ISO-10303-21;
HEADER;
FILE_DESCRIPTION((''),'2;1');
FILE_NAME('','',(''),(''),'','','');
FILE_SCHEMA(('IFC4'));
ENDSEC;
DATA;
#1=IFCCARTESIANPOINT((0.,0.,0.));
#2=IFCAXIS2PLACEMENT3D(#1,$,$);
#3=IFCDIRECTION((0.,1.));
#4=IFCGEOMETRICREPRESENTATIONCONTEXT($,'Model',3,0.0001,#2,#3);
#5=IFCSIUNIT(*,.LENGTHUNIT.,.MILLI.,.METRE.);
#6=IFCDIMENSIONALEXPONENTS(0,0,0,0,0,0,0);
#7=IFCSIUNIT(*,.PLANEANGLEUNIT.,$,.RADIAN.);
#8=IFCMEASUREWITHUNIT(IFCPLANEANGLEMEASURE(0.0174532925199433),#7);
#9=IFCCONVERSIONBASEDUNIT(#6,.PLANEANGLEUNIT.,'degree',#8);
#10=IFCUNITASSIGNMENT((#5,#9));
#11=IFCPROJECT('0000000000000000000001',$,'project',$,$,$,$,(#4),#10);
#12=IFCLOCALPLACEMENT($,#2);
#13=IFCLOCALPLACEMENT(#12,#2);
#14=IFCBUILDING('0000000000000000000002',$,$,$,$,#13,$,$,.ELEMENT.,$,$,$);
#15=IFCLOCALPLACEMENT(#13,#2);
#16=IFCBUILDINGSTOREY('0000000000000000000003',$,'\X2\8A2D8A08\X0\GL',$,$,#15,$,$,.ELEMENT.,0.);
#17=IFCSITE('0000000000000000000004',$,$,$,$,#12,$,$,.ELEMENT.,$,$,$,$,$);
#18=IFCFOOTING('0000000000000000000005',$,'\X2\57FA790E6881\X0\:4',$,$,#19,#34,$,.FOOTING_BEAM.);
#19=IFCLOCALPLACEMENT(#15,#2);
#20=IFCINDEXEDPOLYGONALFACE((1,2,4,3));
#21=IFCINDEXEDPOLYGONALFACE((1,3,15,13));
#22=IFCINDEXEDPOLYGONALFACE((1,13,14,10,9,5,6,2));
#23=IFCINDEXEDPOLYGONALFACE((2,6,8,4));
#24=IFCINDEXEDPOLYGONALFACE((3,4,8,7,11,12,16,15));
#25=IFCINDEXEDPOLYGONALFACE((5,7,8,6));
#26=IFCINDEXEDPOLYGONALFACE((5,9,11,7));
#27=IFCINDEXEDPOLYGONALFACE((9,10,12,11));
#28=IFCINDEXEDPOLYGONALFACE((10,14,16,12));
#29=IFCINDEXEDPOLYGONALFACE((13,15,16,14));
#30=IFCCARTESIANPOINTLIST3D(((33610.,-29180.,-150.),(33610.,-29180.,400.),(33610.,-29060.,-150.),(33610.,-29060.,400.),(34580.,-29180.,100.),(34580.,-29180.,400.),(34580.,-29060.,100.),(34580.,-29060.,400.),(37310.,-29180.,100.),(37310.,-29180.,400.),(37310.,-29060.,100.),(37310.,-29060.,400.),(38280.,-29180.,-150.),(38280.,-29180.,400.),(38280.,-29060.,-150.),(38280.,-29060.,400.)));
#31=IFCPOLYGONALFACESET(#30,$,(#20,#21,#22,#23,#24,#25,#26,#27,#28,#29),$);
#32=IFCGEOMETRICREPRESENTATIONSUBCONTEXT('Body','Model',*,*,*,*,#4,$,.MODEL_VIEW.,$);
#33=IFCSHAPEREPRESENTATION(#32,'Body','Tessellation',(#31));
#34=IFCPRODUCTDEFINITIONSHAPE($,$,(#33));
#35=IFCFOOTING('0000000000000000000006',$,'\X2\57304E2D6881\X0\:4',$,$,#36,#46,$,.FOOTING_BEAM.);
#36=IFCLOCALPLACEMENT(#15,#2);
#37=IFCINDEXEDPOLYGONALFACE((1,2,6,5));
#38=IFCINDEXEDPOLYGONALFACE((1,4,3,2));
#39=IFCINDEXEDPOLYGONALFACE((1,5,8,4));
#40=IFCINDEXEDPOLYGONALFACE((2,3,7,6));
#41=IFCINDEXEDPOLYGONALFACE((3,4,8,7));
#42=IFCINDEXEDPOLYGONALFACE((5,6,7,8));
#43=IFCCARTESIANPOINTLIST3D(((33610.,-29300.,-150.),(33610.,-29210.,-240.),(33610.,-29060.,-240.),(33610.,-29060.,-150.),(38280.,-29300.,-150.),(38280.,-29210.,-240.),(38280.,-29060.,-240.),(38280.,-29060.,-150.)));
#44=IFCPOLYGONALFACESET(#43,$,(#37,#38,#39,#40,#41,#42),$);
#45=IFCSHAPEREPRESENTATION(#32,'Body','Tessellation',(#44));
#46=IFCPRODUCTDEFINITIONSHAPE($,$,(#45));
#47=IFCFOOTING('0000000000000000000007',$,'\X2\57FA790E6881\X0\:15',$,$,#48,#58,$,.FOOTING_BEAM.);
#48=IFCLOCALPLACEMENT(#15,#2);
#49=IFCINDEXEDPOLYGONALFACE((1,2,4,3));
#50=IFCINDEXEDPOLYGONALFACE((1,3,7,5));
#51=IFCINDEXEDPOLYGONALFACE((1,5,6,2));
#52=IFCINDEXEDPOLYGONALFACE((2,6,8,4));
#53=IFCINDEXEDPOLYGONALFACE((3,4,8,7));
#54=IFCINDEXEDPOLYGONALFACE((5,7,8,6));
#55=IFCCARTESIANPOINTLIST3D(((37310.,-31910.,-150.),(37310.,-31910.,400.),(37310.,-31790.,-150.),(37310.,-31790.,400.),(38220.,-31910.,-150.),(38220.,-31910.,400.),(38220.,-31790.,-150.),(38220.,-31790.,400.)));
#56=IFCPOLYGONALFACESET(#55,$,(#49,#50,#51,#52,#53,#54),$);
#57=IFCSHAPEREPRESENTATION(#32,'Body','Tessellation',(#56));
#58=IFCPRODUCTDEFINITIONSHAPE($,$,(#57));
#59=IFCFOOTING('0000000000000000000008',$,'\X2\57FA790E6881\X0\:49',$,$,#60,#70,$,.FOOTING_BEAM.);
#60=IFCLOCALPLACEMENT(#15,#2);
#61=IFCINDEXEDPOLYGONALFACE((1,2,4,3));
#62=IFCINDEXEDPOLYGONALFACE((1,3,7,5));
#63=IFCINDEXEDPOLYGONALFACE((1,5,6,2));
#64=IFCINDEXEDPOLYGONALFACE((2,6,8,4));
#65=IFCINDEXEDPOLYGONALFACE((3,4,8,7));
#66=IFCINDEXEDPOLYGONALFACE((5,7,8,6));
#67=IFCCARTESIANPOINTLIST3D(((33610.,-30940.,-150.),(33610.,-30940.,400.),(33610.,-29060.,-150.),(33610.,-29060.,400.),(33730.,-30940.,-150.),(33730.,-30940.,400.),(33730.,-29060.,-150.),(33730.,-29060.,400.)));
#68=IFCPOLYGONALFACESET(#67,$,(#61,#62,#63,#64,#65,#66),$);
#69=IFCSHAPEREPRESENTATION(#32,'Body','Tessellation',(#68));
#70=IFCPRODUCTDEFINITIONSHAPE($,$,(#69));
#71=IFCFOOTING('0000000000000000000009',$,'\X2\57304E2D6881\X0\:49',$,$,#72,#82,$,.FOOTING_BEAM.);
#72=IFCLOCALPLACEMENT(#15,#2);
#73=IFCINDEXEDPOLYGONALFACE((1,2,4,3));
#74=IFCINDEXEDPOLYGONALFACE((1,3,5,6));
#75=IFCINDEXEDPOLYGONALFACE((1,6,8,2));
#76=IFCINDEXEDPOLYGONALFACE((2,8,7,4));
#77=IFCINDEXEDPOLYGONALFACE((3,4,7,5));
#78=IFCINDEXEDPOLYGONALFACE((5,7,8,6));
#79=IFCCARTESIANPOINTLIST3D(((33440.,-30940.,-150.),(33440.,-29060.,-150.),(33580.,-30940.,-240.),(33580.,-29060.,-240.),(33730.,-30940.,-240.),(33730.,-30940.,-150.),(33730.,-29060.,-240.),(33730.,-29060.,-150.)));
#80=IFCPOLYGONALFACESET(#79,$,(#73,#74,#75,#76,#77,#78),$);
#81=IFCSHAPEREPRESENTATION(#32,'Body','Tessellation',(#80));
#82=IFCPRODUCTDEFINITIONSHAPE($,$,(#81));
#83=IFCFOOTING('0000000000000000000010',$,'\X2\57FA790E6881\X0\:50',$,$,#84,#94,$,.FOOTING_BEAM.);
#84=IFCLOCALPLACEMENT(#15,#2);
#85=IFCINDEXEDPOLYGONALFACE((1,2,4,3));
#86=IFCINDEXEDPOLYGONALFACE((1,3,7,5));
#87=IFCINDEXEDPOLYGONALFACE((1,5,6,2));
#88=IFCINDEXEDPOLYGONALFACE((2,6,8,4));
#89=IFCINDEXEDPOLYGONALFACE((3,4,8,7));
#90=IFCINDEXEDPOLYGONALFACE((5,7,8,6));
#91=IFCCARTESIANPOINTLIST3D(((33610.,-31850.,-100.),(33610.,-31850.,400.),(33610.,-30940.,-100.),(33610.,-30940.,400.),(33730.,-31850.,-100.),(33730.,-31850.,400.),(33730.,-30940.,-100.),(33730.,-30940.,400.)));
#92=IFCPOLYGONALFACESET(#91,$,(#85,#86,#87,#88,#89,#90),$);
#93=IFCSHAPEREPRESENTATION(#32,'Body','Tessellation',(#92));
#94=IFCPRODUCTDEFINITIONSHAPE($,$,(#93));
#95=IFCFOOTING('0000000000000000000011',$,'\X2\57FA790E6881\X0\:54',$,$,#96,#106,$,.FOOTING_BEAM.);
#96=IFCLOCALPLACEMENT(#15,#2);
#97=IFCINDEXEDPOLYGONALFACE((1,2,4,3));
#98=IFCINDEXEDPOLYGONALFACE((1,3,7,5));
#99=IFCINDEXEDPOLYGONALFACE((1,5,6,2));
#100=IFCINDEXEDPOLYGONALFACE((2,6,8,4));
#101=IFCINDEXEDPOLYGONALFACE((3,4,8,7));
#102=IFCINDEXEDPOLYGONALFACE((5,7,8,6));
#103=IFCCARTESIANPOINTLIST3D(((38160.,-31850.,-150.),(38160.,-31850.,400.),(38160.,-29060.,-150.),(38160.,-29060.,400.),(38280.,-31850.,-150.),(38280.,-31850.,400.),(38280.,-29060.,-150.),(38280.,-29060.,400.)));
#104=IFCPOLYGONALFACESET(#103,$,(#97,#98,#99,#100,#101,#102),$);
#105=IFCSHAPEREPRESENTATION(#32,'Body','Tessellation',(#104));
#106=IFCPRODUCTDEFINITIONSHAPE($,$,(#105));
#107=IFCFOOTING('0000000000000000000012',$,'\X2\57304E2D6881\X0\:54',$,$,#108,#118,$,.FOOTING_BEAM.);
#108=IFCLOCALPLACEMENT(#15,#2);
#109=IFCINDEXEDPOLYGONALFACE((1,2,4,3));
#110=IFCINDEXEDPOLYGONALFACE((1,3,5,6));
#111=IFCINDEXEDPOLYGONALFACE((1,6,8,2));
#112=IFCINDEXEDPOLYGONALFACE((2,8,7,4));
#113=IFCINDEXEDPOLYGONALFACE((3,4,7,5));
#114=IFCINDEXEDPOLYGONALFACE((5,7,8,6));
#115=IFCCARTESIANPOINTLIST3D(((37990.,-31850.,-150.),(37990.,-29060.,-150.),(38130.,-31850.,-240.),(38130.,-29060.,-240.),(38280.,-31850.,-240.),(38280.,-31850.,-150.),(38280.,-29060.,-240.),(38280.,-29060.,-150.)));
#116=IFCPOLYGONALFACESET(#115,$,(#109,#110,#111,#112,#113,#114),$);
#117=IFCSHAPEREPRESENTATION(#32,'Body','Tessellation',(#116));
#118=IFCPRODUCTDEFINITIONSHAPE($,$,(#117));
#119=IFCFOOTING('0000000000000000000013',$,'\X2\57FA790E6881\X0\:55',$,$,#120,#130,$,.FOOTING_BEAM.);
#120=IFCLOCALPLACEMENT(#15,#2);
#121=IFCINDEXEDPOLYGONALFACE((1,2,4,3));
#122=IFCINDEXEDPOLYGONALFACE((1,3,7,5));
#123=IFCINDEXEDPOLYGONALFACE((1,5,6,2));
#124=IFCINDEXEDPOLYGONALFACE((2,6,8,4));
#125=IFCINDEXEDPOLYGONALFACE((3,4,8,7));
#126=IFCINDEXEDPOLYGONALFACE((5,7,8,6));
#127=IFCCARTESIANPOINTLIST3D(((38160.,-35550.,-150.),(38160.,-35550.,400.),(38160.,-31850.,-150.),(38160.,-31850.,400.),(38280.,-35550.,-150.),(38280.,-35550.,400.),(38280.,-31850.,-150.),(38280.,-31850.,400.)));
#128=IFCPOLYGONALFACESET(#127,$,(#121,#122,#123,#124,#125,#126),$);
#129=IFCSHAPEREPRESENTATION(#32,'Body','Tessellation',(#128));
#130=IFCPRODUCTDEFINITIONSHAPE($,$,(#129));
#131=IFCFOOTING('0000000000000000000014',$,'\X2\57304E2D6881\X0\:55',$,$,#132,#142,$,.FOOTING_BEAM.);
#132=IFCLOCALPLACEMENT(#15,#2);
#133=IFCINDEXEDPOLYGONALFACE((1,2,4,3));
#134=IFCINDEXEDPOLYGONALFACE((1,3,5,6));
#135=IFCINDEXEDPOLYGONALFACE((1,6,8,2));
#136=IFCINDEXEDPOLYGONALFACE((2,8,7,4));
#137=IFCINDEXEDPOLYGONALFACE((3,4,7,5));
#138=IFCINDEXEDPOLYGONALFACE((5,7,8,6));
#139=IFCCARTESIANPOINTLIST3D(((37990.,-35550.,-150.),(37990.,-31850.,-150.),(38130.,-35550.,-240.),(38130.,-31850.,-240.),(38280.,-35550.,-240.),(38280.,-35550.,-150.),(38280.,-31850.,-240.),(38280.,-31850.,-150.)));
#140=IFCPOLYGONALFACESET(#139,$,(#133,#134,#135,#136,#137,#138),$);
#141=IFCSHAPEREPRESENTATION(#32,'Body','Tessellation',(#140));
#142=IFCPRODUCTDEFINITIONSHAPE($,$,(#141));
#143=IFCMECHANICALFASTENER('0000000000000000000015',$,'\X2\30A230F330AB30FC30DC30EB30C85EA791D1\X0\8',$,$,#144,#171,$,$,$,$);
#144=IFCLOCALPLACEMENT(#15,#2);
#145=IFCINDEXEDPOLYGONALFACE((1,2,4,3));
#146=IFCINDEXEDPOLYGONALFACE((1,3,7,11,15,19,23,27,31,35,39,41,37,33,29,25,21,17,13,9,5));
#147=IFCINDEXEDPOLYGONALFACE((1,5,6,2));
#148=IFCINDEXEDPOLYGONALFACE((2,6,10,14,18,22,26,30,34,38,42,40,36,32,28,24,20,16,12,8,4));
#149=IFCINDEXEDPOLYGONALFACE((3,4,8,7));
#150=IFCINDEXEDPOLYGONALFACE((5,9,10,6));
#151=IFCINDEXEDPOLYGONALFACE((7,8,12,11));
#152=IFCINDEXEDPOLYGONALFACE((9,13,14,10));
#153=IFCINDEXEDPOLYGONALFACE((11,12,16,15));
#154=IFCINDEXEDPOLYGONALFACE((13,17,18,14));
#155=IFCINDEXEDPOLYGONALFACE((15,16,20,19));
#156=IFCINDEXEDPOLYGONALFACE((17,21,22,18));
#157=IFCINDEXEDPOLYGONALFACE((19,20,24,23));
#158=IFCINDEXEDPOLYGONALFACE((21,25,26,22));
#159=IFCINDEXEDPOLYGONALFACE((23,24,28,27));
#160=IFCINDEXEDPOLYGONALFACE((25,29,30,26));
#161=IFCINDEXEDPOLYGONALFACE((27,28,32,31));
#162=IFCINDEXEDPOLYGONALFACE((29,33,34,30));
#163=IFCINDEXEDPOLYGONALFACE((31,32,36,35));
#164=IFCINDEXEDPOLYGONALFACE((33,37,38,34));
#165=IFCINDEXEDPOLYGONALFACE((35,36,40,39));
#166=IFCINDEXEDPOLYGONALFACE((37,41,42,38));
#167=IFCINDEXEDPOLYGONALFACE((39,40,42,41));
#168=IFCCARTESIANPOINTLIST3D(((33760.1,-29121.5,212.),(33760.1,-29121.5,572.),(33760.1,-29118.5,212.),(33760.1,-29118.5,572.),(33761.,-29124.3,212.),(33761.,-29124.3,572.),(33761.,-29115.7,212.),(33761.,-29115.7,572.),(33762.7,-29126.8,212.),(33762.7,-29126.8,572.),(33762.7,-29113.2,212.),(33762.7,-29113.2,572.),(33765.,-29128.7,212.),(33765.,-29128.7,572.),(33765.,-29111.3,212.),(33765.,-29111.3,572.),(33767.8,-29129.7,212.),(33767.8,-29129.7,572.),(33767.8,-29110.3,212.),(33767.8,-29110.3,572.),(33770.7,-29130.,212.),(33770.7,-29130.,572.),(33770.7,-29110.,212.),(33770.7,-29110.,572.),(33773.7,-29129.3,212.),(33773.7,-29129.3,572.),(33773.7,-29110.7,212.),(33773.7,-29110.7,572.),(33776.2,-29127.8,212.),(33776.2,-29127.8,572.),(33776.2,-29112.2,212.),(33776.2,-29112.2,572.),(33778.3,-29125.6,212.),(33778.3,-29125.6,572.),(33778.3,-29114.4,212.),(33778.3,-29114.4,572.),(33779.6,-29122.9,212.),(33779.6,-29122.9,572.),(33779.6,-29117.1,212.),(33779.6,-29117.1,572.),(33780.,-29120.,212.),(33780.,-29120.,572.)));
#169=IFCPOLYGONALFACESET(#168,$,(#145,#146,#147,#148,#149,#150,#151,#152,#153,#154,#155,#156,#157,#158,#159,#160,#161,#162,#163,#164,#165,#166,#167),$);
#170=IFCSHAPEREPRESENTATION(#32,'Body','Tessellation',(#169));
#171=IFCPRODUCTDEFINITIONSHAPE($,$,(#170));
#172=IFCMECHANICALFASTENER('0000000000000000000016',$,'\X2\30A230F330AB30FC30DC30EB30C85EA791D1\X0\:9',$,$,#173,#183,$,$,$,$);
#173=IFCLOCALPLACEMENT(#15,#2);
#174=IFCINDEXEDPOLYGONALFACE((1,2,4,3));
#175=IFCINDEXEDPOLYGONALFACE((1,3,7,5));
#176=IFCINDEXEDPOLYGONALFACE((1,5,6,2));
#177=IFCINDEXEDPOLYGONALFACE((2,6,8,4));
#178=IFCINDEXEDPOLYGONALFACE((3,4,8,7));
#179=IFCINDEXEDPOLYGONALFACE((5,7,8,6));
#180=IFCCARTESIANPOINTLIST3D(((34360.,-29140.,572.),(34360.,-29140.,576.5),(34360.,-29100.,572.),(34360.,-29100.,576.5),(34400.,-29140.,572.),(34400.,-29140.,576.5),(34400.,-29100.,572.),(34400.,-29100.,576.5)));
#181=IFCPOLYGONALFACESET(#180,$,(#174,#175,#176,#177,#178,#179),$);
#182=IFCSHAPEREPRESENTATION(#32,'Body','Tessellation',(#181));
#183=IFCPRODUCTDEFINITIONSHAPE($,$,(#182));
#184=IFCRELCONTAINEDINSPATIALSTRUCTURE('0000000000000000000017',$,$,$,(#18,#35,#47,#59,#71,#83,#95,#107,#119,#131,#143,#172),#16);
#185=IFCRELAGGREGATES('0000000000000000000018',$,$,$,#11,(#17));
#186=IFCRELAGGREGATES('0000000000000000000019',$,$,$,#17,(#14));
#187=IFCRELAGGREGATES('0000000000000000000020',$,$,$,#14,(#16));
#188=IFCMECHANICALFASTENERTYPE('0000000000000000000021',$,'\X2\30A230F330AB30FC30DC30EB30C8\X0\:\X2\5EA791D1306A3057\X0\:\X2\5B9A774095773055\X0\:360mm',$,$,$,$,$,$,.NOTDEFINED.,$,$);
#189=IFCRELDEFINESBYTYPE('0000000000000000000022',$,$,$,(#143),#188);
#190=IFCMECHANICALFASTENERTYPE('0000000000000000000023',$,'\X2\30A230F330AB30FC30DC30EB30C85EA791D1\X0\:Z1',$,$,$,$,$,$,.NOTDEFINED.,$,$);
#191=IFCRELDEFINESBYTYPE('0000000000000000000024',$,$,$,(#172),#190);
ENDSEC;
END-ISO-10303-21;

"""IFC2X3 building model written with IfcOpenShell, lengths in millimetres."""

from ifc_helpers import new_model, entity, si_unit, converted_unit, direction, frame, origin, origin_with_axes, origin_2d, place, context, subcontext, project, spatial, polyline, rectangle, circle, outline, extrude, boolean, type_object, element, save


model = new_model("IFC2X3")

# Units and contexts
model_context = context("Model", 3, precision=0.0001, world=origin(), true_north=direction((0.0, 1.0)))
body_context = subcontext(model_context, "Body", "Model", "MODEL_VIEW")
ifc_project = project(units=[si_unit("LENGTHUNIT", "METRE", prefix="MILLI"), converted_unit("PLANEANGLEUNIT", "degree", entity("IfcPlaneAngleMeasure", 0.0174532925199433), si_unit("PLANEANGLEUNIT", "RADIAN"), dimensions=[0, 0, 0, 0, 0, 0, 0])], contexts=[model_context])

# Site, building, storey
site_placement = place(None, origin())
site = spatial("IfcSite", under=ifc_project, at=site_placement, CompositionType="ELEMENT")
building_placement = place(site_placement, origin())
building = spatial("IfcBuilding", under=site, at=building_placement, CompositionType="ELEMENT")
storey_placement = place(building_placement, origin())
storey = spatial("IfcBuildingStorey", under=building, at=storey_placement, Name="設計GL", CompositionType="ELEMENT", Elevation=0.0)

# Footings
footing_1_placement = place(storey_placement, frame((33610.0, -29120.0, 125.0), z_axis=(1.0, 0.0, 0.0), x_axis=(0.0, 1.0, 0.0)))
element("IfcFooting", 1, at=footing_1_placement, inside=storey, Name="基礎梁:4", PredefinedType="FOOTING_BEAM", context=body_context, shape_type="CSG", body=[
    boolean("DIFFERENCE", extrude(rectangle(XDim=120.0, YDim=550.0, at=origin_2d()), origin_with_axes(), (0.0, 0.0, 1.0), 4670.0), extrude(rectangle(XDim=124.0, YDim=300.0, at=origin_2d()), frame((0.0, 125.0, 970.0), z_axis=(0.0, 0.0, 1.0), x_axis=(1.0, 0.0, 0.0)), (0.0, 0.0, 1.0), 2730.0)),
])
footing_2_placement = place(storey_placement, frame((33610.0, -29060.0, -240.0), z_axis=(1.0, 0.0, 0.0), x_axis=(0.0, 1.0, 0.0)))
element("IfcFooting", 2, at=footing_2_placement, inside=storey, Name="地中梁:4", PredefinedType="FOOTING_BEAM", context=body_context, shape_type="SweptSolid", body=[
    extrude(outline(polyline([(0.0, 0.0, 0.0), (-150.0, 0.0, 0.0), (-240.0, 90.0, 0.0), (0.0, 90.0, 0.0), (0.0, 0.0, 0.0)])), origin_with_axes(), (0.0, 0.0, 1.0), 4670.0),
])
footing_3_placement = place(storey_placement, frame((37310.0, -31850.0, 125.0), z_axis=(1.0, 0.0, 0.0), x_axis=(0.0, 1.0, 0.0)))
element("IfcFooting", 3, at=footing_3_placement, inside=storey, Name="基礎梁:15", PredefinedType="FOOTING_BEAM", context=body_context, shape_type="SolidModel", body=[
    extrude(rectangle(XDim=120.0, YDim=550.0, at=origin_2d()), origin_with_axes(), (0.0, 0.0, 1.0), 910.0),
])
footing_4_placement = place(storey_placement, frame((33670.0, -29060.0, 125.0), z_axis=(0.0, -1.0, 0.0), x_axis=(1.0, 0.0, 0.0)))
element("IfcFooting", 4, at=footing_4_placement, inside=storey, Name="基礎梁:49", PredefinedType="FOOTING_BEAM", context=body_context, shape_type="SolidModel", body=[
    extrude(rectangle(XDim=120.0, YDim=550.0, at=origin_2d()), origin_with_axes(), (0.0, 0.0, 1.0), 1880.0),
])
footing_5_placement = place(storey_placement, frame((33730.0, -29060.0, -240.0), z_axis=(0.0, -1.0, 0.0), x_axis=(1.0, 0.0, 0.0)))
element("IfcFooting", 5, at=footing_5_placement, inside=storey, Name="地中梁:49", PredefinedType="FOOTING_BEAM", context=body_context, shape_type="SweptSolid", body=[
    extrude(outline(polyline([(0.0, 0.0, 0.0), (-150.0, 0.0, 0.0), (-290.0, 90.0, 0.0), (0.0, 90.0, 0.0), (0.0, 0.0, 0.0)])), origin_with_axes(), (0.0, 0.0, 1.0), 1880.0),
])
footing_6_placement = place(storey_placement, frame((33670.0, -30940.0, 150.0), z_axis=(0.0, -1.0, 0.0), x_axis=(1.0, 0.0, 0.0)))
element("IfcFooting", 6, at=footing_6_placement, inside=storey, Name="基礎梁:50", PredefinedType="FOOTING_BEAM", context=body_context, shape_type="SolidModel", body=[
    extrude(rectangle(XDim=120.0, YDim=500.0, at=origin_2d()), origin_with_axes(), (0.0, 0.0, 1.0), 910.0),
])
footing_7_placement = place(storey_placement, frame((38220.0, -29060.0, 125.0), z_axis=(0.0, -1.0, 0.0), x_axis=(1.0, 0.0, 0.0)))
element("IfcFooting", 7, at=footing_7_placement, inside=storey, Name="基礎梁:54", PredefinedType="FOOTING_BEAM", context=body_context, shape_type="SolidModel", body=[
    extrude(rectangle(XDim=120.0, YDim=550.0, at=origin_2d()), origin_with_axes(), (0.0, 0.0, 1.0), 2790.0),
])
footing_8_placement = place(storey_placement, frame((38280.0, -29060.0, -240.0), z_axis=(0.0, -1.0, 0.0), x_axis=(1.0, 0.0, 0.0)))
element("IfcFooting", 8, at=footing_8_placement, inside=storey, Name="地中梁:54", PredefinedType="FOOTING_BEAM", context=body_context, shape_type="SweptSolid", body=[
    extrude(outline(polyline([(0.0, 0.0, 0.0), (-150.0, 0.0, 0.0), (-290.0, 90.0, 0.0), (0.0, 90.0, 0.0), (0.0, 0.0, 0.0)])), origin_with_axes(), (0.0, 0.0, 1.0), 2790.0),
])
footing_9_placement = place(storey_placement, frame((38220.0, -31850.0, 125.0), z_axis=(0.0, -1.0, 0.0), x_axis=(1.0, 0.0, 0.0)))
element("IfcFooting", 9, at=footing_9_placement, inside=storey, Name="基礎梁:55", PredefinedType="FOOTING_BEAM", context=body_context, shape_type="SolidModel", body=[
    extrude(rectangle(XDim=120.0, YDim=550.0, at=origin_2d()), origin_with_axes(), (0.0, 0.0, 1.0), 3700.0),
])
footing_10_placement = place(storey_placement, frame((38280.0, -31850.0, -240.0), z_axis=(0.0, -1.0, 0.0), x_axis=(1.0, 0.0, 0.0)))
element("IfcFooting", 10, at=footing_10_placement, inside=storey, Name="地中梁:55", PredefinedType="FOOTING_BEAM", context=body_context, shape_type="SweptSolid", body=[
    extrude(outline(polyline([(0.0, 0.0, 0.0), (-150.0, 0.0, 0.0), (-290.0, 90.0, 0.0), (0.0, 90.0, 0.0), (0.0, 0.0, 0.0)])), origin_with_axes(), (0.0, 0.0, 1.0), 3700.0),
])

# Mechanical fasteners
mechanical_fastener_type_1 = type_object("IfcMechanicalFastenerType", Name="アンカーボルト:座金なし:定着長さ:360mm")
mechanical_fastener_1_placement = place(storey_placement, frame((33770.0, -29120.0, 212.0)))
element("IfcMechanicalFastener", 11, at=mechanical_fastener_1_placement, inside=storey, type_object=mechanical_fastener_type_1, Name="アンカーボルト座金8", context=body_context, shape_type="SweptSolid", body=[
    extrude(circle(Radius=10.0, at=origin_2d()), origin_with_axes(), (0.0, 0.0, 1.0), 360.0),
])
mechanical_fastener_type_2 = type_object("IfcMechanicalFastenerType", Name="アンカーボルト座金:Z1")
mechanical_fastener_2_placement = place(storey_placement, frame((34380.0, -29120.0, 572.0)))
element("IfcMechanicalFastener", 12, at=mechanical_fastener_2_placement, inside=storey, type_object=mechanical_fastener_type_2, Name="アンカーボルト座金:9", context=body_context, shape_type="SweptSolid", body=[
    extrude(rectangle(XDim=40.0, YDim=40.0, at=origin_2d()), origin_with_axes(), (0.0, 0.0, 1.0), 4.5),
])

save(model, "model.ifc")
